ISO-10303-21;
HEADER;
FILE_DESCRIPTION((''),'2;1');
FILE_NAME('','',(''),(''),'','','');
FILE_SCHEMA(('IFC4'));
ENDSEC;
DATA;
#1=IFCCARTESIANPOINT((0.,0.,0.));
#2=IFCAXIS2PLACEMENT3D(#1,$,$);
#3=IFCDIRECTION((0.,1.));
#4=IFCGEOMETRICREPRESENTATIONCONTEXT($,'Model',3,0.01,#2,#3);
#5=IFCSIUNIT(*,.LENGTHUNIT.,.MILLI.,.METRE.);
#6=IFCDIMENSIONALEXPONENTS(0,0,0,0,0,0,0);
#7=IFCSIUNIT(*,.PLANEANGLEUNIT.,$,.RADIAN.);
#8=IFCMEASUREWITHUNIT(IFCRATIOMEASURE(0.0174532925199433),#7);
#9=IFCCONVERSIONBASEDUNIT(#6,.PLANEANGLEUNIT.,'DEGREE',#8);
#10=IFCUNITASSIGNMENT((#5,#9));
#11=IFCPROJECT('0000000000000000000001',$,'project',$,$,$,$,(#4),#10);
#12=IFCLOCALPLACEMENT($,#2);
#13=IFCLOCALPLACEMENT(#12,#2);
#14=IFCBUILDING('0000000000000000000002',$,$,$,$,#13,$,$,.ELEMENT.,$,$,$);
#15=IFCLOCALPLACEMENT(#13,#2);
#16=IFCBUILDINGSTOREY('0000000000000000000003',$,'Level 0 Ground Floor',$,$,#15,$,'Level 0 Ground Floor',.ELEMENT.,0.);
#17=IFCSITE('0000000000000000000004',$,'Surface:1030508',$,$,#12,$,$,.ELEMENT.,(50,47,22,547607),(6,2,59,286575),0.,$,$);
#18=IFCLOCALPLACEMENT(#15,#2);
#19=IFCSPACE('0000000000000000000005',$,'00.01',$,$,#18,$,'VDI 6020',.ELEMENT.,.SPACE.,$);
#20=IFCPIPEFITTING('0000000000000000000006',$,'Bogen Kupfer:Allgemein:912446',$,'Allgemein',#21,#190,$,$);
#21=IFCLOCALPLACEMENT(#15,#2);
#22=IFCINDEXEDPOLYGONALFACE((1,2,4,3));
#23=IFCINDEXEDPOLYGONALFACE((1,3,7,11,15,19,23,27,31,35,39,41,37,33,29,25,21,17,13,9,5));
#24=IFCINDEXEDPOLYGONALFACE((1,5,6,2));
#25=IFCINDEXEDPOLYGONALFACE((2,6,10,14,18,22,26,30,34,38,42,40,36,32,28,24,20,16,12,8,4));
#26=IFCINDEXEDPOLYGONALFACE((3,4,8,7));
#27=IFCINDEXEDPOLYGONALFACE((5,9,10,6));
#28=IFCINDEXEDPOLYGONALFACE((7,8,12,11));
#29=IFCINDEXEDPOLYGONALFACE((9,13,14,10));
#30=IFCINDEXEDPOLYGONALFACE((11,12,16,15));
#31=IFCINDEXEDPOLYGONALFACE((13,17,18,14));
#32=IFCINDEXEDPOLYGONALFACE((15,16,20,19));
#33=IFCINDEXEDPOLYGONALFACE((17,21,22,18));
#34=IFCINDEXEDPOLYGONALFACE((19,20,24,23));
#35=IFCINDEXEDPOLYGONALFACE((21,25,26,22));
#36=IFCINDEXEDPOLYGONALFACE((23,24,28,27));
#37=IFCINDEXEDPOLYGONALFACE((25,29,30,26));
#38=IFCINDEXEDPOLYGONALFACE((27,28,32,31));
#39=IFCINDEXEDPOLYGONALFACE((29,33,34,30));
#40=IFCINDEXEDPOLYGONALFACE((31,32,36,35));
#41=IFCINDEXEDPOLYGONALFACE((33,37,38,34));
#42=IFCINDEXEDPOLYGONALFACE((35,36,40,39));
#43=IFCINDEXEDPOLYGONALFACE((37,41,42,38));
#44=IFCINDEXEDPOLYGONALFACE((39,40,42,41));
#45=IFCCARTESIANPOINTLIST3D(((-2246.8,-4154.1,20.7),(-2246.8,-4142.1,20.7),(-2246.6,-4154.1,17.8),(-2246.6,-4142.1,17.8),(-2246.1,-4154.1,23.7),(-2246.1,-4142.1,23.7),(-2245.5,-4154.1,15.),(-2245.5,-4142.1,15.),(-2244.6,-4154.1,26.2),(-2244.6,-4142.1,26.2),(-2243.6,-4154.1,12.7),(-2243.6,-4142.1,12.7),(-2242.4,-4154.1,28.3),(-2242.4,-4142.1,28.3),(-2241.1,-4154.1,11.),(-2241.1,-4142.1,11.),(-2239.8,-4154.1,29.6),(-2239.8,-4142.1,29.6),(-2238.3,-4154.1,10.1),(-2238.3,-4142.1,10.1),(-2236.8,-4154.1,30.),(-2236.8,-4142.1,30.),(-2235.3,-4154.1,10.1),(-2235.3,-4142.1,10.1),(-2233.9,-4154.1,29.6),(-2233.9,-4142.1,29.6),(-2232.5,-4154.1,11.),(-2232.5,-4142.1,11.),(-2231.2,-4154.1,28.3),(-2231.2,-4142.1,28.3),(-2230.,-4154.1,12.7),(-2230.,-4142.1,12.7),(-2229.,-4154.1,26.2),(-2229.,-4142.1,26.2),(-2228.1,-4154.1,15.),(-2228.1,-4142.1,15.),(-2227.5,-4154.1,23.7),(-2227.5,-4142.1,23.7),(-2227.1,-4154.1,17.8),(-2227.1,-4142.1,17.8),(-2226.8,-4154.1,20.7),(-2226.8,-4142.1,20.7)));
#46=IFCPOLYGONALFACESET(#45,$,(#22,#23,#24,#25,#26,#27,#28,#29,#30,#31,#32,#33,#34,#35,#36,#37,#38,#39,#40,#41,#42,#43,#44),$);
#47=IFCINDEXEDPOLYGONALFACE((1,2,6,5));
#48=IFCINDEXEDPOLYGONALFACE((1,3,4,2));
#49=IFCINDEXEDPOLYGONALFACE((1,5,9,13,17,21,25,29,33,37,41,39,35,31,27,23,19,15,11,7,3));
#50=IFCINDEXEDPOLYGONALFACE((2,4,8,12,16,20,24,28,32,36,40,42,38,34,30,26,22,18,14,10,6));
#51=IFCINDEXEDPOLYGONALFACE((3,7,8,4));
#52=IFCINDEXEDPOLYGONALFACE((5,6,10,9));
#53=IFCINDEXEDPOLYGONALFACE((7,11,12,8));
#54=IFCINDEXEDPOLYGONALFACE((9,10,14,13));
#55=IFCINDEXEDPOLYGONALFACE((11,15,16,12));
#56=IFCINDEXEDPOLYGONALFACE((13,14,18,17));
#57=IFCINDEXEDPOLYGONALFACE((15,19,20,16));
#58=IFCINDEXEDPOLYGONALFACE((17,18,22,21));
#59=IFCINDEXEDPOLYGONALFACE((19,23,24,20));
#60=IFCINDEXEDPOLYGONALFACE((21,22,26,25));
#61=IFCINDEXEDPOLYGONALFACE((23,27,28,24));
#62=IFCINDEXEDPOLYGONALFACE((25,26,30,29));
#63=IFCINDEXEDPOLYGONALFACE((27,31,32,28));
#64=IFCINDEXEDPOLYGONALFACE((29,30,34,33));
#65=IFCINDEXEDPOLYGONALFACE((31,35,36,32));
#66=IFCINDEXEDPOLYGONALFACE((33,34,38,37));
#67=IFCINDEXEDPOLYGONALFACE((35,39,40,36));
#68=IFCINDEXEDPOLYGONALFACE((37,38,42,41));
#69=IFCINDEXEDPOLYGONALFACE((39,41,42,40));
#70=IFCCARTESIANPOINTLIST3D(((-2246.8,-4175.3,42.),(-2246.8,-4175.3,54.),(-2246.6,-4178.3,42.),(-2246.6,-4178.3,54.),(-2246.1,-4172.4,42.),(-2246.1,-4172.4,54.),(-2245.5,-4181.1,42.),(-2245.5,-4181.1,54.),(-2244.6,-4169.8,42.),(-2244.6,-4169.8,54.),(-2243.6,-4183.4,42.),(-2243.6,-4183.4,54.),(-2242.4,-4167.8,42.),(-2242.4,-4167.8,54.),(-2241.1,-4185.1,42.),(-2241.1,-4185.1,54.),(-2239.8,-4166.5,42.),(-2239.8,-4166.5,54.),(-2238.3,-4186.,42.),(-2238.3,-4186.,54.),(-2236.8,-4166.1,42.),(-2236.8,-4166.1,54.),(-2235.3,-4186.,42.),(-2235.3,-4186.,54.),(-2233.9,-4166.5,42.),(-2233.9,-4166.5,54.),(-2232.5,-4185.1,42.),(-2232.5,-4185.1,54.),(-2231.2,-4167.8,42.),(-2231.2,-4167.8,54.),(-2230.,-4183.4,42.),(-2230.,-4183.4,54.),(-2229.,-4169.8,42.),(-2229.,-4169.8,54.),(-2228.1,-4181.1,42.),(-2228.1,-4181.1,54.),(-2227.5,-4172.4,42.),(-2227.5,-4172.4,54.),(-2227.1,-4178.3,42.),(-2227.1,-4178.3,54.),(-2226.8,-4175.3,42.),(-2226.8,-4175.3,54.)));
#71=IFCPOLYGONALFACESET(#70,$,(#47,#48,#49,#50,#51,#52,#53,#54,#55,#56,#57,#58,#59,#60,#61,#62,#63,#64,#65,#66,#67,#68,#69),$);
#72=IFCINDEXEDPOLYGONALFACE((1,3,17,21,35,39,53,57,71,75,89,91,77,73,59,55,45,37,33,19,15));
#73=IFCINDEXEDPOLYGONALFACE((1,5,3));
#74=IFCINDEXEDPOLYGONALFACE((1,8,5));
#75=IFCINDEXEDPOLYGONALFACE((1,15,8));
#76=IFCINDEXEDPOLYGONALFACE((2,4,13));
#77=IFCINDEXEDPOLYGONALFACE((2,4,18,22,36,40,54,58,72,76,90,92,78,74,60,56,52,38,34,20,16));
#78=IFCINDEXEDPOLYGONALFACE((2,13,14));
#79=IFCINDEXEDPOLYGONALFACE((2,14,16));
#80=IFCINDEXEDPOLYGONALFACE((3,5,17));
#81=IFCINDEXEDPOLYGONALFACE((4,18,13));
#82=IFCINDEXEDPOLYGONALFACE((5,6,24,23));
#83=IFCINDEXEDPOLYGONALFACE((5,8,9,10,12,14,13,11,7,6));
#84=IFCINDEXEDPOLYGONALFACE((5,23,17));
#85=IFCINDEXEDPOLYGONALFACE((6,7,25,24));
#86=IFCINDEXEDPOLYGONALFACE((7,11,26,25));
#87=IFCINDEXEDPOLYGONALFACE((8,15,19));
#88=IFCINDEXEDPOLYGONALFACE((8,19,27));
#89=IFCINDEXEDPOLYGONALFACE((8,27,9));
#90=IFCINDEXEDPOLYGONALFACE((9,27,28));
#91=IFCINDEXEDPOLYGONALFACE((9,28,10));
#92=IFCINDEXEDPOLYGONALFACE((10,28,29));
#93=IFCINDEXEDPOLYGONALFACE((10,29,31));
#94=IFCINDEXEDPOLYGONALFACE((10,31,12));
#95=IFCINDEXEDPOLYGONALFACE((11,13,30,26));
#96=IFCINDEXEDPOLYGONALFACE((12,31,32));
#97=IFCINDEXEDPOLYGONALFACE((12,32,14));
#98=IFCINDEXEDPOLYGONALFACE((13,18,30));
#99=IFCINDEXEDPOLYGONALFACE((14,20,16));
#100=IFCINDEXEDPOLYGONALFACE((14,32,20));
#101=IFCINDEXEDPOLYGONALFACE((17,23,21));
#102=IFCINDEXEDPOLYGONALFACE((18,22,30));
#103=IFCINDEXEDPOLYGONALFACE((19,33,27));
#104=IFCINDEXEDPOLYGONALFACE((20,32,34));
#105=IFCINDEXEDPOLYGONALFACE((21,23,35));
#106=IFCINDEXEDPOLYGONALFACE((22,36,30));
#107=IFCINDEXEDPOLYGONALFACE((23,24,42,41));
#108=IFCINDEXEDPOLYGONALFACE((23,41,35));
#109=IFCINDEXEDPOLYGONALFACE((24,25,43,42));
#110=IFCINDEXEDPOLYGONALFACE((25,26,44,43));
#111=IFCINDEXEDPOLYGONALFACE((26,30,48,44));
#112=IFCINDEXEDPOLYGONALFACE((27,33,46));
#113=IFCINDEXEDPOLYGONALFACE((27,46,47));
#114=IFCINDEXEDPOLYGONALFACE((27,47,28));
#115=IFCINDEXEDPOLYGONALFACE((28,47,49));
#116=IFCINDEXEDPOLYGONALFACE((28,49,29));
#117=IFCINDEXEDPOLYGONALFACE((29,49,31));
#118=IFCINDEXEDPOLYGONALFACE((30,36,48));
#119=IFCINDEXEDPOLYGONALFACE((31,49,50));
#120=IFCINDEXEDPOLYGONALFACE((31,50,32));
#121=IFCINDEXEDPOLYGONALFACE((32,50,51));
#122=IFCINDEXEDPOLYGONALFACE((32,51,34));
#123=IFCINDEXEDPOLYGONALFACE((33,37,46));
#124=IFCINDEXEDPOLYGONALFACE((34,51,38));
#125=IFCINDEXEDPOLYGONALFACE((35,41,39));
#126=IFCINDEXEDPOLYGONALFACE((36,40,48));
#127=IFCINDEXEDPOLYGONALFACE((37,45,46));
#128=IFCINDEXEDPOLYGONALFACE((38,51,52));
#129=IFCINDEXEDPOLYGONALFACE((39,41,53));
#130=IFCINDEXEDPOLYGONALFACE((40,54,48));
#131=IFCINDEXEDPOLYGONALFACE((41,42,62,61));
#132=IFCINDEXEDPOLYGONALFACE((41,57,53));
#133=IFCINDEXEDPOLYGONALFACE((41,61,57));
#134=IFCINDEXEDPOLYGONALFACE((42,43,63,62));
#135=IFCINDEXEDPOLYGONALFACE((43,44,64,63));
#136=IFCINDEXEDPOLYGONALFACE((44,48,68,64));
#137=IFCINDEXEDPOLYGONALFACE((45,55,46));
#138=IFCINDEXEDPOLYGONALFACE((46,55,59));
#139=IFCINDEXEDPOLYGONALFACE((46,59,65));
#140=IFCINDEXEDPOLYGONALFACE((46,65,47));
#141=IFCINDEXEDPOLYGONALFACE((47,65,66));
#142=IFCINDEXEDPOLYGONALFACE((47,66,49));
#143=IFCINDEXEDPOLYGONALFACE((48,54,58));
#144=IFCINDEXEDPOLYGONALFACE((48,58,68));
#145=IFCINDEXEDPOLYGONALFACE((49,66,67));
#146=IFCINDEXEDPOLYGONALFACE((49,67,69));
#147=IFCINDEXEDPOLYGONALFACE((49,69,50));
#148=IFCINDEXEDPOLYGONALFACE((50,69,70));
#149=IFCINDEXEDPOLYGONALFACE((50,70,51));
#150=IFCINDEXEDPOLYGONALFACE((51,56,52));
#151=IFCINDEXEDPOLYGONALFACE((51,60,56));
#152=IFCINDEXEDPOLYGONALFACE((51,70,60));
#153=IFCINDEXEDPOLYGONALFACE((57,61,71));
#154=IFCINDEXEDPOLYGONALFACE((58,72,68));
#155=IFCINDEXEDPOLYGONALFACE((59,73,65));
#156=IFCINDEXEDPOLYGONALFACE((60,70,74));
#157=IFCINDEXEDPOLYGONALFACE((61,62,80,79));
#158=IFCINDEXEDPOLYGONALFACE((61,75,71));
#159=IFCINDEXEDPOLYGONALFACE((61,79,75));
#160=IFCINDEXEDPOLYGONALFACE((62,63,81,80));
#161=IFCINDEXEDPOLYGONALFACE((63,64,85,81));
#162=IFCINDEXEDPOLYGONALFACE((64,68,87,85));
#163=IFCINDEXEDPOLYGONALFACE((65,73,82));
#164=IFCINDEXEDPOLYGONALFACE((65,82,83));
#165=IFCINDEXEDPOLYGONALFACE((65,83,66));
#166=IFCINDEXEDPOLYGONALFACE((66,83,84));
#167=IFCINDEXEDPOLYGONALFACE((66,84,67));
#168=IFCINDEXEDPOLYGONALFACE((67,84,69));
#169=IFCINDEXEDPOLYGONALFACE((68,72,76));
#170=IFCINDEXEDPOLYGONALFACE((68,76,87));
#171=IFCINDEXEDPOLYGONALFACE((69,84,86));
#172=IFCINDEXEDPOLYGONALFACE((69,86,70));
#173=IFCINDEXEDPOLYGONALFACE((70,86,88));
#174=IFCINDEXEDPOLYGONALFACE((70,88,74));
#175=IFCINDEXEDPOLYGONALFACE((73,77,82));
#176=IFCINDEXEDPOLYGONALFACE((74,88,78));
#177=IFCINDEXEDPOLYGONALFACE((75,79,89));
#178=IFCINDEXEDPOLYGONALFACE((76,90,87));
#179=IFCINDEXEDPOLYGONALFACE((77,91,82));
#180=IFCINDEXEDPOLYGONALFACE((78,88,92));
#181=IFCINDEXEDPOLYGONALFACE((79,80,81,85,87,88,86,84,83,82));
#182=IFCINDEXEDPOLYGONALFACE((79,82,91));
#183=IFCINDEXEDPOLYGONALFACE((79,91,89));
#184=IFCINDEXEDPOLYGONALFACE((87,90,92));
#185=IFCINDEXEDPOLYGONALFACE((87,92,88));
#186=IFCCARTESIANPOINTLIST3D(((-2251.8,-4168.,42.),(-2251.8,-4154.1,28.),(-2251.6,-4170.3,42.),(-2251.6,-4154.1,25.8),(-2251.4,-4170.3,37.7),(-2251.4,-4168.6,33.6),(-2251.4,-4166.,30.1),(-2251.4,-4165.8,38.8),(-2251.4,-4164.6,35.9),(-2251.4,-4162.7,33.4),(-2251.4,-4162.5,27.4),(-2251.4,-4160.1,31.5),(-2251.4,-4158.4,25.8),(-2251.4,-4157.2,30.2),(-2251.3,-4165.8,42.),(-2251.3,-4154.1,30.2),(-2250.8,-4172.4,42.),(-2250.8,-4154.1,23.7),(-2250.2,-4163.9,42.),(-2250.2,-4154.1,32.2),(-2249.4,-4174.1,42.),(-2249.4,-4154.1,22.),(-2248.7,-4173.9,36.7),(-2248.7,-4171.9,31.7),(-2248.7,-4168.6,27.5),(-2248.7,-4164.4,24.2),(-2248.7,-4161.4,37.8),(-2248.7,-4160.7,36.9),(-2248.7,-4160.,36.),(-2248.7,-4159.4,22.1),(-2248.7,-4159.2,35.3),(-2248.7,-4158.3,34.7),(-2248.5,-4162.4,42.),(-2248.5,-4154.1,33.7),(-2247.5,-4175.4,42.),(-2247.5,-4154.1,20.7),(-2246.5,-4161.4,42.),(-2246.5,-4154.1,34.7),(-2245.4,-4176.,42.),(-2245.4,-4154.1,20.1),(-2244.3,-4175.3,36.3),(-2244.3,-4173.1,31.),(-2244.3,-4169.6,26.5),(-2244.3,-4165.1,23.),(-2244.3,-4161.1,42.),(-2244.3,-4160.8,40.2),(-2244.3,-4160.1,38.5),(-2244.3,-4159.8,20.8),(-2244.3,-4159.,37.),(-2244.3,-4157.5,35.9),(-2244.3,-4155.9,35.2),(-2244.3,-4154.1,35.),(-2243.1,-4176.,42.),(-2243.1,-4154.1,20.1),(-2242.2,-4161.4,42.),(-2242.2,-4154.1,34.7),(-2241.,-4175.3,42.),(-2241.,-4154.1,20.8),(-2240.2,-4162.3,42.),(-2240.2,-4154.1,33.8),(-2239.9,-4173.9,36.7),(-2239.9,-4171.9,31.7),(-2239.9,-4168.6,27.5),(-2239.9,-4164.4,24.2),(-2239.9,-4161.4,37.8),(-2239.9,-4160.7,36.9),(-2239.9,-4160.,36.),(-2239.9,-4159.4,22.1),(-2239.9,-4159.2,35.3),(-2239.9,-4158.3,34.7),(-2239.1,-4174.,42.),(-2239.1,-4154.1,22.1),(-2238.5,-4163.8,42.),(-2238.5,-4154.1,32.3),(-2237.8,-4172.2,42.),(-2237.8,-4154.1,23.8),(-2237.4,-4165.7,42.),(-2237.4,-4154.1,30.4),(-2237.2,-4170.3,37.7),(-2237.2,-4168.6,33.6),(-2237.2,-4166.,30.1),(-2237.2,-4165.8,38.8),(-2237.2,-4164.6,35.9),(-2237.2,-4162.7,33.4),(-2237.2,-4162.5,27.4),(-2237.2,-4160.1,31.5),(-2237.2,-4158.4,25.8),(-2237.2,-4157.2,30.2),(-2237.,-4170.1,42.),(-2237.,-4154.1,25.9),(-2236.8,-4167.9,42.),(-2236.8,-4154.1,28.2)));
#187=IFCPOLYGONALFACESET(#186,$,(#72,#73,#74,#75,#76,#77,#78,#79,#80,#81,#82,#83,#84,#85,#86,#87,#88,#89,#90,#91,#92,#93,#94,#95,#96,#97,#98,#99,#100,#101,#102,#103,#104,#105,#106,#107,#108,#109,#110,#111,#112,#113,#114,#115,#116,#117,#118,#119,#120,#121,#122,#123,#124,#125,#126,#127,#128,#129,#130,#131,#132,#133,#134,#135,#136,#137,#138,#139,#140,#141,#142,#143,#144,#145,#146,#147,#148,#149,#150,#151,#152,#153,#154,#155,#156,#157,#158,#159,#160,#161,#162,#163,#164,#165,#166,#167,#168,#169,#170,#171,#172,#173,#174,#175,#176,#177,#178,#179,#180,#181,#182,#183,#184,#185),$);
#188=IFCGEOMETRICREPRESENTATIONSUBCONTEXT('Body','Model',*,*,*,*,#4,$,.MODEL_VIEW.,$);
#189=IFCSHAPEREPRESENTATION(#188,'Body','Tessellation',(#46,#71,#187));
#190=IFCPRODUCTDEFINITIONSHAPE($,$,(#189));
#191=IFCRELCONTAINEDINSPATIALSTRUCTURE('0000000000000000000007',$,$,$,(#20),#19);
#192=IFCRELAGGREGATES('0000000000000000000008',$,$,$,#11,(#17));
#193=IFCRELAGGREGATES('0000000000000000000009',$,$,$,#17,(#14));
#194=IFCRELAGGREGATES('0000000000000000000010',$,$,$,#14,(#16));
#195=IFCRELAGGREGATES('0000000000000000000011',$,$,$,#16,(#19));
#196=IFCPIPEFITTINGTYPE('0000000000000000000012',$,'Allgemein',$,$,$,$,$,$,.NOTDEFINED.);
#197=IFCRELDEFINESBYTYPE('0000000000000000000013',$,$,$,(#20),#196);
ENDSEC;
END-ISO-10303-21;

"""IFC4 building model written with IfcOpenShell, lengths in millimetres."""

from ifc_helpers import new_model, entity, si_unit, converted_unit, direction, frame, frame_2d, origin, place, context, subcontext, project, spatial, circle, extrude, source, transform, mapped, type_object, type_shapes, element, save


model = new_model("IFC4")

# Units and contexts
model_context = context("Model", 3, precision=0.01, world=origin(), true_north=direction((0.0, 1.0)))
body_context = subcontext(model_context, "Body", "Model", "MODEL_VIEW")
ifc_project = project(units=[si_unit("LENGTHUNIT", "METRE", prefix="MILLI"), converted_unit("PLANEANGLEUNIT", "DEGREE", entity("IfcRatioMeasure", 0.0174532925199433), si_unit("PLANEANGLEUNIT", "RADIAN"), dimensions=[0, 0, 0, 0, 0, 0, 0])], contexts=[model_context])

# Site, building, storey
site_placement = place(None, origin())
site = spatial("IfcSite", under=ifc_project, at=site_placement, Name="Surface:1030508", CompositionType="ELEMENT", RefLatitude=(50, 47, 22, 547607), RefLongitude=(6, 2, 59, 286575), RefElevation=0.0)
building_placement = place(site_placement, origin())
building = spatial("IfcBuilding", under=site, at=building_placement, CompositionType="ELEMENT")
storey_placement = place(building_placement, origin())
storey = spatial("IfcBuildingStorey", under=building, at=storey_placement, Name="Level 0 Ground Floor", LongName="Level 0 Ground Floor", CompositionType="ELEMENT", Elevation=0.0)

# Shared definitions
pipe_fitting_type_1 = type_object("IfcPipeFittingType", Name="Allgemein", PredefinedType="NOTDEFINED")
ifc_direction_1 = entity("IfcDirection", [0.0, 0.0, -1.0])
trimmed_curve_1 = entity("IfcTrimmedCurve", entity("IfcCircle", entity("IfcAxis2Placement2D", entity("IfcCartesianPoint", [-14.5, 0.0]), entity("IfcDirection", [0.0, 1.0])), 14.5), [entity("IfcParameterValue", 270.0)], [entity("IfcParameterValue", 0.0)], True, "PARAMETER")
shared_shape_1 = source(origin(), body_context, "Body", "SolidModel", [
    extrude(circle(Radius=10.0, at=frame_2d((0.0, 0.0), x_axis=(1.0, 0.0))), frame((0.0, 22.0, 0.0), z_axis=(0.0, 1.0, 0.0), x_axis=(-1.0, 0.0, 0.0)), (0.0, 0.0, 1.0), 12.0),
    extrude(circle(Radius=10.0, at=frame_2d((0.0, 0.0), x_axis=(1.0, 0.0))), frame((-34.0, 0.0, 0.0), z_axis=(1.0, 0.0, 0.0), x_axis=(0.0, 1.0, 0.0)), (0.0, 0.0, 1.0), 12.0),
    entity("IfcSurfaceCurveSweptAreaSolid", entity("IfcCircleProfileDef", "AREA", None, entity("IfcAxis2Placement2D", entity("IfcCartesianPoint", [0.0, 7.5]), entity("IfcDirection", [1.0, 0.0])), 7.5), entity("IfcAxis2Placement3D", entity("IfcCartesianPoint", [-7.5, 22.0, 0.0]), ifc_direction_1, entity("IfcDirection", [1.0, 0.0, 0.0])), trimmed_curve_1, 0.0, 90.0, entity("IfcSurfaceOfLinearExtrusion", entity("IfcArbitraryOpenProfileDef", "CURVE", None, trimmed_curve_1), entity("IfcAxis2Placement3D", entity("IfcCartesianPoint", [0.0, 0.0, -304.8])), ifc_direction_1, 1.0)),
])
type_shapes(pipe_fitting_type_1, [shared_shape_1])

# Shared definitions
space_placement = place(storey_placement, origin())
space = spatial("IfcSpace", under=storey, at=space_placement, Name="00.01", LongName="VDI 6020", CompositionType="ELEMENT", PredefinedType="SPACE")

# Pipe fitting
for number, where, z_axis, x_axis, name in (
    (1, (-2236.8, -4176.1, 20.0), (1.0, 0.0, 0.0), (0.0, 0.0, -1.0), "Bogen Kupfer:Allgemein:912446"),
):
    element("IfcPipeFitting", number, at=place(space_placement, frame(where, z_axis=z_axis, x_axis=x_axis)), inside=space, type_object=pipe_fitting_type_1, Name=name, ObjectType="Allgemein", context=body_context, shape_type="MappedRepresentation", body=[
        mapped(shared_shape_1, transform((0.0, 0.0, 0.0), scale=1.0)),
    ])

save(model, "model.ifc")
